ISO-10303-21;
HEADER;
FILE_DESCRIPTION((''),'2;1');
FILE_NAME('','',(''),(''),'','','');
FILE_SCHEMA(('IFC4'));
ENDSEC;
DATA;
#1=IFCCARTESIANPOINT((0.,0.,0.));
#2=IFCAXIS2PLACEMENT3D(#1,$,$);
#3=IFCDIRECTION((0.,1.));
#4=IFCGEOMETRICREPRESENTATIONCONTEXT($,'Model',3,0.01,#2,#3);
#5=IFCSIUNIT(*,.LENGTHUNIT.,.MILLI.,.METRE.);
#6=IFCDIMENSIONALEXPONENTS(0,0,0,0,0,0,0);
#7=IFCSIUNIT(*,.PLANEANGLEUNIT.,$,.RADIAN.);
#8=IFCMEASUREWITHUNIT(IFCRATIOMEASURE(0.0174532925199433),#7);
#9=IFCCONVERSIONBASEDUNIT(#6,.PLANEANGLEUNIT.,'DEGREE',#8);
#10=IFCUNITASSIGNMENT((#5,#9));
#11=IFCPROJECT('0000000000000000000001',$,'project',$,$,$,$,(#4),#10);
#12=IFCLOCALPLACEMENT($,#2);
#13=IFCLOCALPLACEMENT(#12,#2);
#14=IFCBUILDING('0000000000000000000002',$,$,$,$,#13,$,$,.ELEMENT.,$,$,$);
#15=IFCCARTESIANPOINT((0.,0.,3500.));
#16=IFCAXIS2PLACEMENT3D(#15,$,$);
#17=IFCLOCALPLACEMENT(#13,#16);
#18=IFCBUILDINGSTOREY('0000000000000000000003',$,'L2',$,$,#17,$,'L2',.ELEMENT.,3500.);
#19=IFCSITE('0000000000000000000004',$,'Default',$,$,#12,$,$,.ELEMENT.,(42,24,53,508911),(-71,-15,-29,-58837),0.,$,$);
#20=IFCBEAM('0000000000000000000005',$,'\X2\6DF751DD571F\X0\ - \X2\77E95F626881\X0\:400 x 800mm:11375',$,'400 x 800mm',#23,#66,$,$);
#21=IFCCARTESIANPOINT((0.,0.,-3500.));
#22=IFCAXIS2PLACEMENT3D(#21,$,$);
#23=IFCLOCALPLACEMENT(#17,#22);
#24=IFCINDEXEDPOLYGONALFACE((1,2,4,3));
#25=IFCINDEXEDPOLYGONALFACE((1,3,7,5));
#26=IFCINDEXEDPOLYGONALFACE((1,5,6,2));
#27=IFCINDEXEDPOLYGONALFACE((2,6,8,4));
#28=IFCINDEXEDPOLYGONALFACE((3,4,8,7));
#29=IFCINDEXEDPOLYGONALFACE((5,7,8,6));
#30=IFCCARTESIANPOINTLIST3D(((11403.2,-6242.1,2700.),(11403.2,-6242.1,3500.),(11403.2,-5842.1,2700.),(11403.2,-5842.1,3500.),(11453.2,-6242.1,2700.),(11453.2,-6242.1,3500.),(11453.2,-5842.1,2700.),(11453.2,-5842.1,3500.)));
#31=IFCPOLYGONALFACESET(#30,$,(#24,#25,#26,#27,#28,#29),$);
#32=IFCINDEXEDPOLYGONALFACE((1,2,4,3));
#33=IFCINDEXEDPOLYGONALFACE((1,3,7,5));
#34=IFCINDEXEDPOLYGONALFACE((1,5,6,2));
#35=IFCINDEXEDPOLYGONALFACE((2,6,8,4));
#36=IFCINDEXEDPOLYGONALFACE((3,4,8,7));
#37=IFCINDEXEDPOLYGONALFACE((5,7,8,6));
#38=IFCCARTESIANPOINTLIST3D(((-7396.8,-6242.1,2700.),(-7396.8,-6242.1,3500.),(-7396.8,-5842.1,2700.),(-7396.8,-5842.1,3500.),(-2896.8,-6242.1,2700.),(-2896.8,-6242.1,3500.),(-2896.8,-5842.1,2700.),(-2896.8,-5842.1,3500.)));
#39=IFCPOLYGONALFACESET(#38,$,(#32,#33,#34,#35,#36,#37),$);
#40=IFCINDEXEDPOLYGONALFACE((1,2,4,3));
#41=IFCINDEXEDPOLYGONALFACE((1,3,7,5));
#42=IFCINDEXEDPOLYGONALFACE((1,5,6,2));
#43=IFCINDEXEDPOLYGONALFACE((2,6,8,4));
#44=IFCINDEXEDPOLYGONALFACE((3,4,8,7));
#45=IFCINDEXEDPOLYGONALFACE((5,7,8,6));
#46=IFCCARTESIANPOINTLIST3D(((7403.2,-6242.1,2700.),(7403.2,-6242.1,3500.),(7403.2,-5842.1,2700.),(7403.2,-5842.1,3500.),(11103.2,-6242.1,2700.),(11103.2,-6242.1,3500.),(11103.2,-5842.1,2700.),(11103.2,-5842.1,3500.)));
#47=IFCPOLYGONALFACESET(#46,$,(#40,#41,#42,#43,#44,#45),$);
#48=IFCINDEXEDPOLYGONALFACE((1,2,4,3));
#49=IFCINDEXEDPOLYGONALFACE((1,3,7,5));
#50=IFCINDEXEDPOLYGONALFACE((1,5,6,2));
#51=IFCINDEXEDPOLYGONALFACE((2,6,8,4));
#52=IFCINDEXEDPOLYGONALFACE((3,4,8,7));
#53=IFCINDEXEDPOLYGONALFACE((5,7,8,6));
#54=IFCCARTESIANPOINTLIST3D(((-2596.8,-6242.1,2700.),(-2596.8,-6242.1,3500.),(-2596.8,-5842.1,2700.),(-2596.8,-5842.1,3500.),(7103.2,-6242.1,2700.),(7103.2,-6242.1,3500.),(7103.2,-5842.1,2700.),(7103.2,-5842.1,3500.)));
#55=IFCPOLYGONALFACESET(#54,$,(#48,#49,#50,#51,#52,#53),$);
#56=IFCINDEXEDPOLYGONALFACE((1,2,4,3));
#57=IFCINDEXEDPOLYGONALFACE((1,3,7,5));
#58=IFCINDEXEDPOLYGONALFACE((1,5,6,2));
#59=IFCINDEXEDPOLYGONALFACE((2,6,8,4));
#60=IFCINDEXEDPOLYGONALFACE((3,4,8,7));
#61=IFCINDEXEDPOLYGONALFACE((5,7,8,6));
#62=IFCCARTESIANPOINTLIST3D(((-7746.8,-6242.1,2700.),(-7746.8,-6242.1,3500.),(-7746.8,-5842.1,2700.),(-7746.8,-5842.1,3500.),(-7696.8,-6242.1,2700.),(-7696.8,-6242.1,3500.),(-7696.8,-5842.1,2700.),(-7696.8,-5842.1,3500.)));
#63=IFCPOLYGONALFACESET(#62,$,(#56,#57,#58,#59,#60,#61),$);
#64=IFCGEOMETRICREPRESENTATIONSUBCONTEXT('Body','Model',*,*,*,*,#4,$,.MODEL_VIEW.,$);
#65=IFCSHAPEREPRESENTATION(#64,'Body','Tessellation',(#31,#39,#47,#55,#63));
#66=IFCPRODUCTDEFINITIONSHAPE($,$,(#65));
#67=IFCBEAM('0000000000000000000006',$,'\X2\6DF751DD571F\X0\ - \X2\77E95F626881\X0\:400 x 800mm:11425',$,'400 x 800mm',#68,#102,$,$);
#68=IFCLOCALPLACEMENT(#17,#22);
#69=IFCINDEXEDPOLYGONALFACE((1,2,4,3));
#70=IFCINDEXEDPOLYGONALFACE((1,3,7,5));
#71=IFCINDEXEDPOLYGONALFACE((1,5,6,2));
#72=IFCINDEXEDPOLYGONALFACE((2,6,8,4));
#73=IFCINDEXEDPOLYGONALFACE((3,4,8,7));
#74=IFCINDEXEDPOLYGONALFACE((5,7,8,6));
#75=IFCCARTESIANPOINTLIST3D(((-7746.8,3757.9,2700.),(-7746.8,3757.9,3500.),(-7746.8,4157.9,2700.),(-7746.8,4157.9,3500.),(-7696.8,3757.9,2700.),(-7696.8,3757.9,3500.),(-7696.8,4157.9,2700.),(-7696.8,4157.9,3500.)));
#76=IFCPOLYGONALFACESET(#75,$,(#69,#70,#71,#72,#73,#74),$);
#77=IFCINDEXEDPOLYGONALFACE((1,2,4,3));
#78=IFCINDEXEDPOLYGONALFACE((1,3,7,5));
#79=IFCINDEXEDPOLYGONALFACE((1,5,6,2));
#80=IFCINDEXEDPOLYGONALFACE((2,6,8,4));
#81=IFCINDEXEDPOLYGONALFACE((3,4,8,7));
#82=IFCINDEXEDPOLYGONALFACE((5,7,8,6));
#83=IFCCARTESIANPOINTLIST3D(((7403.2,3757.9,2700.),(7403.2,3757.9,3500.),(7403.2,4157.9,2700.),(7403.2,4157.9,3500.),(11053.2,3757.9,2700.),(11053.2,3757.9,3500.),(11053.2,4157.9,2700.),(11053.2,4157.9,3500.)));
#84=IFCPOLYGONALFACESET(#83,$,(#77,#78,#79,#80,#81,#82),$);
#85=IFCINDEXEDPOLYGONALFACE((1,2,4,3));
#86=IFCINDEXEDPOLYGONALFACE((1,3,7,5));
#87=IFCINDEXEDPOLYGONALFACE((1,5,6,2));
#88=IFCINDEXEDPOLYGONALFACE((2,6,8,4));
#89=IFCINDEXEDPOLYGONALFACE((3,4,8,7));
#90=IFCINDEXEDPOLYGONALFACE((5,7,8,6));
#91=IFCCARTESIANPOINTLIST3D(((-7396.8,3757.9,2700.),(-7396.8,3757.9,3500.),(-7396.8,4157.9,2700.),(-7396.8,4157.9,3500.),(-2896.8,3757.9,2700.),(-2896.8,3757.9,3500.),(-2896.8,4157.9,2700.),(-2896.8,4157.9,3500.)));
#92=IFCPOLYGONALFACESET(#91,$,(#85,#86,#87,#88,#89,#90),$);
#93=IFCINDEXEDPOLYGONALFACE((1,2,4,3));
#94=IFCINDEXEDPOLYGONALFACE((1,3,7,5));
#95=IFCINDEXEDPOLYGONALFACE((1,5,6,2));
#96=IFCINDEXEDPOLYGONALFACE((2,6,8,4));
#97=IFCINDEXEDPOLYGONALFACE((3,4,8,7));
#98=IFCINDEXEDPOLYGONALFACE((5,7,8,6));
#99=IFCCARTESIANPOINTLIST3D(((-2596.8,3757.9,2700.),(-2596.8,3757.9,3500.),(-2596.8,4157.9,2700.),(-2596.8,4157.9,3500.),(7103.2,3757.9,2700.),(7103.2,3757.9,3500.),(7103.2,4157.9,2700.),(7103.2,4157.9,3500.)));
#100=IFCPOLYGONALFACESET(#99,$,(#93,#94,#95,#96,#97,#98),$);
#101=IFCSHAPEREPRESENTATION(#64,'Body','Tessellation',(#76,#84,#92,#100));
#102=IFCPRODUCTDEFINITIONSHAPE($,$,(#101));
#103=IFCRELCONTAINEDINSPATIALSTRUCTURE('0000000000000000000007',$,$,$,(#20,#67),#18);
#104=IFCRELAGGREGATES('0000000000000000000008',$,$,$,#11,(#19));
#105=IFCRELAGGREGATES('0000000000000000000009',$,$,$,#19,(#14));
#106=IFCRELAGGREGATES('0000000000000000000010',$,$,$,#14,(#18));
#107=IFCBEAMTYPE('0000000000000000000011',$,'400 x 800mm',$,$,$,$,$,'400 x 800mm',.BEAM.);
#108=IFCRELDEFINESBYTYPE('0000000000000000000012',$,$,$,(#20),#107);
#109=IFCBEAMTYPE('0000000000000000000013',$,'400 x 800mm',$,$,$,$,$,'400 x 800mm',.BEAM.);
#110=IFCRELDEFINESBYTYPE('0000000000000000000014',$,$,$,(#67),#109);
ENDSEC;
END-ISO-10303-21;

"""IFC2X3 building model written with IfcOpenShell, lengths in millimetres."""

from ifc_helpers import new_model, entity, si_unit, converted_unit, direction, frame, frame_2d, origin, origin_2d_with_axis, place, context, subcontext, project, spatial, rectangle, extrude, source, transform, mapped, type_object, type_shapes, element, save


model = new_model("IFC2X3")

# Units and contexts
model_context = context("Model", 3, precision=0.01, world=origin(), true_north=direction((0.0, 1.0)))
body_context = subcontext(model_context, "Body", "Model", "MODEL_VIEW")
ifc_project = project(units=[si_unit("LENGTHUNIT", "METRE", prefix="MILLI"), converted_unit("PLANEANGLEUNIT", "DEGREE", entity("IfcRatioMeasure", 0.0174532925199433), si_unit("PLANEANGLEUNIT", "RADIAN"), dimensions=[0, 0, 0, 0, 0, 0, 0])], contexts=[model_context])

# Site, building, storey
site_placement = place(None, origin())
site = spatial("IfcSite", under=ifc_project, at=site_placement, Name="Default", CompositionType="ELEMENT", RefLatitude=(42, 24, 53, 508911), RefLongitude=(-71, -15, -29, -58837), RefElevation=0.0)
building_placement = place(site_placement, origin())
building = spatial("IfcBuilding", under=site, at=building_placement, CompositionType="ELEMENT")
storey_placement = place(building_placement, frame((0.0, 0.0, 3500.0)))
storey = spatial("IfcBuildingStorey", under=building, at=storey_placement, Name="L2", LongName="L2", CompositionType="ELEMENT", Elevation=3500.0)

# Beams
beam_type_1 = type_object("IfcBeamType", Name="400 x 800mm", ElementType="400 x 800mm", PredefinedType="BEAM")
shared_shape_1 = source(origin(), body_context, "Body", "SweptSolid", [
    extrude(rectangle(XDim=50.0, YDim=400.0, at=frame_2d((0.0, 0.0), x_axis=(1.0, 0.0))), frame((11428.2, -6042.1, 2700.0), z_axis=(0.0, 0.0, 1.0), x_axis=(-1.0, 0.0, 0.0)), (0.0, 0.0, 1.0), 800.0),
    extrude(rectangle(XDim=4500.0, YDim=400.0, at=frame_2d((440.0, -40.0), x_axis=(1.0, 0.0))), frame((-5586.8, -6002.1, 2700.0)), (0.0, 0.0, 1.0), 800.0),
    extrude(rectangle(XDim=3700.0, YDim=400.0, at=frame_2d((360.0, 40.0), x_axis=(1.0, 0.0))), frame((9613.2, -6002.1, 2700.0), z_axis=(0.0, 0.0, 1.0), x_axis=(-1.0, 0.0, 0.0)), (0.0, 0.0, 1.0), 800.0),
    extrude(rectangle(XDim=9700.0, YDim=400.0, at=origin_2d_with_axis()), frame((2253.2, -6042.1, 2700.0)), (0.0, 0.0, 1.0), 800.0),
    extrude(rectangle(XDim=50.0, YDim=400.0, at=frame_2d((0.0, 0.0), x_axis=(1.0, 0.0))), frame((-7721.8, -6042.1, 2700.0)), (0.0, 0.0, 1.0), 800.0),
])
type_shapes(beam_type_1, [shared_shape_1])
beam_1_placement = place(storey_placement, frame((0.0, 0.0, -3500.0)))
element("IfcBeam", 1, at=beam_1_placement, inside=storey, type_object=beam_type_1, Name="混凝土 - 矩形梁:400 x 800mm:11375", ObjectType="400 x 800mm", context=body_context, shape_type="MappedRepresentation", body=[
    mapped(shared_shape_1, transform((0.0, 0.0, 0.0), scale=1.0)),
])
beam_type_2 = type_object("IfcBeamType", Name="400 x 800mm", ElementType="400 x 800mm", PredefinedType="BEAM")
shared_shape_2 = source(origin(), body_context, "Body", "SweptSolid", [
    extrude(rectangle(XDim=50.0, YDim=400.0, at=frame_2d((0.0, 0.0), x_axis=(1.0, 0.0))), frame((-7721.8, 3957.9, 2700.0)), (0.0, 0.0, 1.0), 800.0),
    extrude(rectangle(XDim=3650.0, YDim=400.0, at=frame_2d((0.0, 0.0), x_axis=(1.0, 0.0))), frame((9228.2, 3957.9, 2700.0), z_axis=(0.0, 0.0, 1.0), x_axis=(-1.0, 0.0, 0.0)), (0.0, 0.0, 1.0), 800.0),
    extrude(rectangle(XDim=4500.0, YDim=400.0, at=frame_2d((440.0, 40.0), x_axis=(1.0, 0.0))), frame((-5586.8, 3917.9, 2700.0)), (0.0, 0.0, 1.0), 800.0),
    extrude(rectangle(XDim=9700.0, YDim=400.0, at=origin_2d_with_axis()), frame((2253.2, 3957.9, 2700.0), z_axis=(0.0, 0.0, 1.0), x_axis=(-1.0, 0.0, 0.0)), (0.0, 0.0, 1.0), 800.0),
])
type_shapes(beam_type_2, [shared_shape_2])
beam_2_placement = place(storey_placement, frame((0.0, 0.0, -3500.0)))
element("IfcBeam", 2, at=beam_2_placement, inside=storey, type_object=beam_type_2, Name="混凝土 - 矩形梁:400 x 800mm:11425", ObjectType="400 x 800mm", context=body_context, shape_type="MappedRepresentation", body=[
    mapped(shared_shape_2, transform((0.0, 0.0, 0.0), scale=1.0)),
])

save(model, "model.ifc")
